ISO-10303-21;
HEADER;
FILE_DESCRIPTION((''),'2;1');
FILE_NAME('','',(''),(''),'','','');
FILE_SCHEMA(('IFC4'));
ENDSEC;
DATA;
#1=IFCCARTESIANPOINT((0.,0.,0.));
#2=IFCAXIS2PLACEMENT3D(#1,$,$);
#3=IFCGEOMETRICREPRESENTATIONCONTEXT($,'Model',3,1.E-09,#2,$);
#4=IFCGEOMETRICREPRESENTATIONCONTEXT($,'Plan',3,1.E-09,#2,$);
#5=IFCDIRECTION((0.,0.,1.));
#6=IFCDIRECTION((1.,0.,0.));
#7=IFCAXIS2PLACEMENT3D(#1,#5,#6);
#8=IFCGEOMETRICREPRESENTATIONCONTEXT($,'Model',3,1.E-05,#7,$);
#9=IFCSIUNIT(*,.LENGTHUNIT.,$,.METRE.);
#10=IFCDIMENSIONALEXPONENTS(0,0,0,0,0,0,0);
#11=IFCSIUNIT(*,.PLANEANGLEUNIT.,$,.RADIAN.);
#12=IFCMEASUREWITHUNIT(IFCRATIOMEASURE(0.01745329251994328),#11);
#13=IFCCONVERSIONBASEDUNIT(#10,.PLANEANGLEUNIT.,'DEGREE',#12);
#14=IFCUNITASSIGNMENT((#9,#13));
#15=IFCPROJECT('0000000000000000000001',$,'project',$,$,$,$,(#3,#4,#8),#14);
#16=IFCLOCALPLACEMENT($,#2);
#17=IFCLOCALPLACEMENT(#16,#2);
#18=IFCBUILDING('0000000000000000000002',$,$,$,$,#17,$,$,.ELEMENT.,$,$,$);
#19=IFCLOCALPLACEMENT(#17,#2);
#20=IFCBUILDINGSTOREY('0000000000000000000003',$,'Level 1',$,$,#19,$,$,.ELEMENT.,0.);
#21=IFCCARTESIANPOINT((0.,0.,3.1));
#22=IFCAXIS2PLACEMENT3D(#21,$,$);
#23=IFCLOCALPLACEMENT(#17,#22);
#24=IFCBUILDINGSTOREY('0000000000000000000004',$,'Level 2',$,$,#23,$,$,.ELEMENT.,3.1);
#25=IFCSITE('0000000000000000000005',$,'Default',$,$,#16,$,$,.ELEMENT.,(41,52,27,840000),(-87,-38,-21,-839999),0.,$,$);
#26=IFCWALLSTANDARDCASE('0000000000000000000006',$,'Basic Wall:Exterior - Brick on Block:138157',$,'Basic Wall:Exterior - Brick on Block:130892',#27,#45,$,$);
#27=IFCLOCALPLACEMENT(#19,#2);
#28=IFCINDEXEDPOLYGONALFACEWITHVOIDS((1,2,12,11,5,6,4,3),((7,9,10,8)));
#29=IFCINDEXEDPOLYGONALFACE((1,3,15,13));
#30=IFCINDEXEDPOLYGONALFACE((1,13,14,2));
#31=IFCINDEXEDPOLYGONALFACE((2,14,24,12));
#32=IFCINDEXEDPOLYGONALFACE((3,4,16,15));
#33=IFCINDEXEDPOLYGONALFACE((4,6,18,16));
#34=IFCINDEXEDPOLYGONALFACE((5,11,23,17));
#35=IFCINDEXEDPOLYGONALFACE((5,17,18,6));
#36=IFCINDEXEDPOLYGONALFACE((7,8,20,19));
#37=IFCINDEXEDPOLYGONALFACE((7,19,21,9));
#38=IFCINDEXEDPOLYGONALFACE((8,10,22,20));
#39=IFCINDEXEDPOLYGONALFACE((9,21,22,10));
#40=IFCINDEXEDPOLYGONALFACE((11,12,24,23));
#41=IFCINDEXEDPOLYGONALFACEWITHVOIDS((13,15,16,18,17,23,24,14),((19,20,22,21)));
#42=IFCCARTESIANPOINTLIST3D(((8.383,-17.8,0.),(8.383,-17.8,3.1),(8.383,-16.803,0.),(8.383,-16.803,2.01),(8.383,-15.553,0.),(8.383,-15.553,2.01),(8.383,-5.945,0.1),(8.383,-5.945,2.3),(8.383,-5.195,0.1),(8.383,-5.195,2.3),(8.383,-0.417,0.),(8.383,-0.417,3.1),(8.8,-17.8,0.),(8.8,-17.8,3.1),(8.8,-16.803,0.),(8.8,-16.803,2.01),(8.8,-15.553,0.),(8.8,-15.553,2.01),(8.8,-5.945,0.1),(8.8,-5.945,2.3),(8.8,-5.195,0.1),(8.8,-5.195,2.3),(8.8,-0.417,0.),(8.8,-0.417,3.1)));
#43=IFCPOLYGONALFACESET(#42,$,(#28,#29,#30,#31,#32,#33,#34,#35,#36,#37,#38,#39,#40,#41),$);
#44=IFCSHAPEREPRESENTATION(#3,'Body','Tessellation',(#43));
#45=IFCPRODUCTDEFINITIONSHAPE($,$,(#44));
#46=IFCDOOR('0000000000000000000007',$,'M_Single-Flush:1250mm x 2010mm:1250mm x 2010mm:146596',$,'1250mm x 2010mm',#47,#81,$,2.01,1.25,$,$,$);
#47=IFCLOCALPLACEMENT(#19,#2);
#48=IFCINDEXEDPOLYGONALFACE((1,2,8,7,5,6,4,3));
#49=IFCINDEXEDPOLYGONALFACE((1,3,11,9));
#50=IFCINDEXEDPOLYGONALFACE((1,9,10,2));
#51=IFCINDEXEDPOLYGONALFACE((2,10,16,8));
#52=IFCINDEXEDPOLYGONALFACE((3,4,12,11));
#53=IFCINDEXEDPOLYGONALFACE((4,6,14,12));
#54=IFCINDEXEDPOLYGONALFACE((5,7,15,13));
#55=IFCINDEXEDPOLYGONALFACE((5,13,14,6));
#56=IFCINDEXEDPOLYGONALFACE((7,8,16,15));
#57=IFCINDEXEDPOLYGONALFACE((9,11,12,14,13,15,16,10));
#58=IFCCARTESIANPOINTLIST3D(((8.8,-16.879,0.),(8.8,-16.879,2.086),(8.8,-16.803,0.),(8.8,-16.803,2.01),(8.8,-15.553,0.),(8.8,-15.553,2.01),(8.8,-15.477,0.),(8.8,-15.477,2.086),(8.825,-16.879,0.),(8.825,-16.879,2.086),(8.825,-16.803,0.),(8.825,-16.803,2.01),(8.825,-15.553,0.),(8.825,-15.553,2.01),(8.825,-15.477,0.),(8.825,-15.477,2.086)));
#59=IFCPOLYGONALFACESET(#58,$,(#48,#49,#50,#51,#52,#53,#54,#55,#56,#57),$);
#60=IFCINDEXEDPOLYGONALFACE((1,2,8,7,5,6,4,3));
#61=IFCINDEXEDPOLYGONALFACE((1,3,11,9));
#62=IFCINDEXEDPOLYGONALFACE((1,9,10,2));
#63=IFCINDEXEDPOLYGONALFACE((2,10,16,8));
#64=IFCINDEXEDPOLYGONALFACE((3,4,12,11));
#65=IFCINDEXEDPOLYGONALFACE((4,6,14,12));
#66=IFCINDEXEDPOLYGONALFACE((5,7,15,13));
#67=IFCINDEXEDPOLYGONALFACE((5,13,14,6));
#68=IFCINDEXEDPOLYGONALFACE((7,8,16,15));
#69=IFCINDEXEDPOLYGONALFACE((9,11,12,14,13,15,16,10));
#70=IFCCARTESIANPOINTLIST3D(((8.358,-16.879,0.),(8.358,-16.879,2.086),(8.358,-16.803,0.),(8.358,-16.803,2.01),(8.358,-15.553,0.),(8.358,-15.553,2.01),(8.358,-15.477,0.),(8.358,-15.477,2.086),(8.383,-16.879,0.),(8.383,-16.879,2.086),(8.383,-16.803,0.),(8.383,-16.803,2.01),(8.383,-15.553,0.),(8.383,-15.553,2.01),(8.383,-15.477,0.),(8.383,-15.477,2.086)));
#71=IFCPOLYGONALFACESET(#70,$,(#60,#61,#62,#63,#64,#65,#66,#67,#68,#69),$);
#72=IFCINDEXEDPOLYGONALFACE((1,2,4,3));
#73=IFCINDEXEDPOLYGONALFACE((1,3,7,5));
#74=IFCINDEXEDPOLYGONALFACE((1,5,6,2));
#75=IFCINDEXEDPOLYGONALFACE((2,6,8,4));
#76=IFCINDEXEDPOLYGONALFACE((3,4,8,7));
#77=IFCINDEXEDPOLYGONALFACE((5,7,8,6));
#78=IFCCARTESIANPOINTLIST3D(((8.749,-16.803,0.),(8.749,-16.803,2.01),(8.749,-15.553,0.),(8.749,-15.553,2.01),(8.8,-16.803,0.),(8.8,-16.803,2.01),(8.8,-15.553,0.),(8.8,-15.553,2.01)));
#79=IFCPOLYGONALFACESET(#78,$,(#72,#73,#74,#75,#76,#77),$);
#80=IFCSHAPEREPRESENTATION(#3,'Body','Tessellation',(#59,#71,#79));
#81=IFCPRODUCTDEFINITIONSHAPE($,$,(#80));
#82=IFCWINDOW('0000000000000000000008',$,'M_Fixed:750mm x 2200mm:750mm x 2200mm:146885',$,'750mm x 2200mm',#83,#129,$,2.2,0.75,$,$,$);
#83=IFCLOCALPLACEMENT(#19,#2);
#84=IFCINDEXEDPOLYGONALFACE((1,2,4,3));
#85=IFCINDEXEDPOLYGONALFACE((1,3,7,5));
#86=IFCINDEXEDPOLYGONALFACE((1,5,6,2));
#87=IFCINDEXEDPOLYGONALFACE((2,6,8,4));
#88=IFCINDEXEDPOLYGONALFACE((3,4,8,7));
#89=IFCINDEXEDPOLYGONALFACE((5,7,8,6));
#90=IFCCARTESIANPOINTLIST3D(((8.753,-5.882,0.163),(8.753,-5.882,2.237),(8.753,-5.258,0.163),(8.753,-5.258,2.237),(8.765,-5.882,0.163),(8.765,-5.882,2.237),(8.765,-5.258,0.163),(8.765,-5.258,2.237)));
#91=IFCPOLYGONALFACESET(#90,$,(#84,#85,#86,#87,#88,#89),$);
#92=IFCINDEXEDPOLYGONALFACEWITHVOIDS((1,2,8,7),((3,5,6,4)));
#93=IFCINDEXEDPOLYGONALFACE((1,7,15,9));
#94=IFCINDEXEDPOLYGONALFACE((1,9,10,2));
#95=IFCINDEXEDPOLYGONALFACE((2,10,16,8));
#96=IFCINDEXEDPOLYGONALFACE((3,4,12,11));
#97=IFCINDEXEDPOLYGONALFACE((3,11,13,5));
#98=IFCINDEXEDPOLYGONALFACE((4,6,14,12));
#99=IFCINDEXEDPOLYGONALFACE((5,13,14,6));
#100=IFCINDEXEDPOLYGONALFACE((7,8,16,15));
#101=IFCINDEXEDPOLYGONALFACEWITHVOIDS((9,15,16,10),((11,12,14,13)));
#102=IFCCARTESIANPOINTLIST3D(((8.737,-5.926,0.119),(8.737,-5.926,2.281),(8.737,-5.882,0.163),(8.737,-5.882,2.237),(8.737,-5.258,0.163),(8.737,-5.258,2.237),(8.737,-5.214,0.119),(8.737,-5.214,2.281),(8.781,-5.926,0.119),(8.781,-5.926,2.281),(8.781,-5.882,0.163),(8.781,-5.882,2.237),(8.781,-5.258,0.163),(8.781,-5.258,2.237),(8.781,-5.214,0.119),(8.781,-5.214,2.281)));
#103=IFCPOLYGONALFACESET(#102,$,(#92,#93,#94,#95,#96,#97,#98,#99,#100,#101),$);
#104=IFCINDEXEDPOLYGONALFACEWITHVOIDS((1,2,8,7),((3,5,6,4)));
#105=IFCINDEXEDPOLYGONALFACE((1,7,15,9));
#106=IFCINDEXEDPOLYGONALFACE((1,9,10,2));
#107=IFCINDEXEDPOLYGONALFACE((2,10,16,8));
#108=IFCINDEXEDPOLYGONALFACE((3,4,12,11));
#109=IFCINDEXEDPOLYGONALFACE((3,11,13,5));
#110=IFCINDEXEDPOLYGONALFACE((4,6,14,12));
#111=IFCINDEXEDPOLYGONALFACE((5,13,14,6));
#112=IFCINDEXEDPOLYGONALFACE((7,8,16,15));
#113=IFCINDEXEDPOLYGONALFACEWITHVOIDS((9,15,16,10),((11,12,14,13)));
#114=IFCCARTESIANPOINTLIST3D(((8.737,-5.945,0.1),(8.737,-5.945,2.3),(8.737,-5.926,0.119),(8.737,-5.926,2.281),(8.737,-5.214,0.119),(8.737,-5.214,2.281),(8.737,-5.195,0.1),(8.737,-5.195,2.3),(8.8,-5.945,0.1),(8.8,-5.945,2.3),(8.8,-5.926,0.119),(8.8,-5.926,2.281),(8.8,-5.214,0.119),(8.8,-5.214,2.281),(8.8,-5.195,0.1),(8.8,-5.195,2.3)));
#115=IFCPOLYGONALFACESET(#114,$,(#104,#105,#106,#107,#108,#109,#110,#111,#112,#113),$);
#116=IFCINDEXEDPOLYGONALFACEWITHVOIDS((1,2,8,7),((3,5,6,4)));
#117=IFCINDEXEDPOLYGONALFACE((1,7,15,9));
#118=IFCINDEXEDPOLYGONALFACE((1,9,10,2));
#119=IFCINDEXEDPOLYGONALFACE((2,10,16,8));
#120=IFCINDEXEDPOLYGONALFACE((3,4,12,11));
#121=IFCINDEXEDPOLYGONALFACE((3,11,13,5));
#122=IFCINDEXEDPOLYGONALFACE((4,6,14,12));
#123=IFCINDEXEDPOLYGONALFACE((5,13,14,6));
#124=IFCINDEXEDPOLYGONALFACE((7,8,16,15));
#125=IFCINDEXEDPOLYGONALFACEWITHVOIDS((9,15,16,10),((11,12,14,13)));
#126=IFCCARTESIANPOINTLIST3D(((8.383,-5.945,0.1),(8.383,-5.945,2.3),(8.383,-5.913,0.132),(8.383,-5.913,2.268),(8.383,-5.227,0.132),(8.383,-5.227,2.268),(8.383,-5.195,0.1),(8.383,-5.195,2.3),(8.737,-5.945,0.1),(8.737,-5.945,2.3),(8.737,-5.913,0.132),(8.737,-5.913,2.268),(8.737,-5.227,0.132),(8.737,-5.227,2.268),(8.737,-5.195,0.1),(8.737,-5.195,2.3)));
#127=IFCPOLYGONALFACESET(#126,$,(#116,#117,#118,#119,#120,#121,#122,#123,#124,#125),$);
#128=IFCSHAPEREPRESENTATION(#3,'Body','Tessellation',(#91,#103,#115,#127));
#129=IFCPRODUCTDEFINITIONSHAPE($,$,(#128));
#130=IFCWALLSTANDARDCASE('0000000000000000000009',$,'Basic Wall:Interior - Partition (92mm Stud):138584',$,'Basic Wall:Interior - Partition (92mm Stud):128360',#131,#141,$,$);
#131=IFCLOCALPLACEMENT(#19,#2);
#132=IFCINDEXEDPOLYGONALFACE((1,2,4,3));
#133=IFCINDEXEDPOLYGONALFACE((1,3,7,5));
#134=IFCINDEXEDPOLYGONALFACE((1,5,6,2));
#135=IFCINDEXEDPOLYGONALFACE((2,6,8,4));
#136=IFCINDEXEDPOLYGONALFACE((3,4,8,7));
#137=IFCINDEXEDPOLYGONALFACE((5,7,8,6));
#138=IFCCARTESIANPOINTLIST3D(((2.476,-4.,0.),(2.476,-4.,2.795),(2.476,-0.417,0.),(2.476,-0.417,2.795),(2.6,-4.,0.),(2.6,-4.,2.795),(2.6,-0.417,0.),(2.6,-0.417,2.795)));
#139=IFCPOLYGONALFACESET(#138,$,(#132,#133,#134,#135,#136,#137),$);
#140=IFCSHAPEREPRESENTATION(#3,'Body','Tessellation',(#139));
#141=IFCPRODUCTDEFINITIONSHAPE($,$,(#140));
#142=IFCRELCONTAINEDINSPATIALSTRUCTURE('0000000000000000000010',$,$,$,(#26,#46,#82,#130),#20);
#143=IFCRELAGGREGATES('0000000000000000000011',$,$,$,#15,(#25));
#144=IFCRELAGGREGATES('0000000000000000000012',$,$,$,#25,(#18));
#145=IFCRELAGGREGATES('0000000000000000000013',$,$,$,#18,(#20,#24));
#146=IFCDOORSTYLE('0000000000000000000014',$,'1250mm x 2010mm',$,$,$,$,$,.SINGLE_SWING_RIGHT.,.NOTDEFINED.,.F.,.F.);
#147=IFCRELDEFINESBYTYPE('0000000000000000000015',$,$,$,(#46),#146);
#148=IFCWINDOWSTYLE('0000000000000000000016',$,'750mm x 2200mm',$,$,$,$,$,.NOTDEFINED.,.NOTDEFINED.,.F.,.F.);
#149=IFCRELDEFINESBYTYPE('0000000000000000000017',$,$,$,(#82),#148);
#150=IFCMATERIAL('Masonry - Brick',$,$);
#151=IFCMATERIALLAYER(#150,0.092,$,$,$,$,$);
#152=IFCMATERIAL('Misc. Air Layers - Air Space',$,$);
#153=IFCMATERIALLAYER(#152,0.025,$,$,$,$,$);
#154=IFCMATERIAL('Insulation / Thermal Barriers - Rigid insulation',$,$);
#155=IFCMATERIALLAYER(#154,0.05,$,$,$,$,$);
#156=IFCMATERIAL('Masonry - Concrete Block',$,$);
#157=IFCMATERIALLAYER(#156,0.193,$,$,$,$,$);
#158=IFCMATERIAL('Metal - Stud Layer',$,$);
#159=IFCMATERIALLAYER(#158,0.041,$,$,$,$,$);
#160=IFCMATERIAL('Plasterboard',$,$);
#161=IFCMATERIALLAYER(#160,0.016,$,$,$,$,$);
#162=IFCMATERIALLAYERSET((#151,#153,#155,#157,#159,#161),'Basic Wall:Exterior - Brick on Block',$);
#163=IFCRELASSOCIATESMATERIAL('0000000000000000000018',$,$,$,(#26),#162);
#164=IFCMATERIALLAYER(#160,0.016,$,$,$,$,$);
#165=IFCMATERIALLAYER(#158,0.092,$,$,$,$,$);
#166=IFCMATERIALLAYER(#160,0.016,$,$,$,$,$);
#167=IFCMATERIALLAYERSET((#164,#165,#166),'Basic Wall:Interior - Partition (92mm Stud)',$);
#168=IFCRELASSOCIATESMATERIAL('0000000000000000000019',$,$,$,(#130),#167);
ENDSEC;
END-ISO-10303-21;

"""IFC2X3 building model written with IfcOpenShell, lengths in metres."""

from ifc_helpers import new_model, entity, si_unit, converted_unit, frame, frame_2d, origin, origin_with_axes, origin_2d_with_axis, place, context, project, spatial, polyline, rectangle, outline, extrude, source, transform, mapped, material, layer, layer_set, layer_usage, type_object, type_shapes, element, fill, save


model = new_model("IFC2X3")

# Units and contexts
model_context_1 = context("Model", 3, precision=1e-09, world=origin())
plan_context = context("Plan", 3, precision=1e-09, world=origin())
model_context_2 = context("Model", 3, precision=1e-05, world=origin_with_axes())
ifc_project = project(units=[si_unit("LENGTHUNIT", "METRE"), converted_unit("PLANEANGLEUNIT", "DEGREE", entity("IfcRatioMeasure", 0.01745329251994328), si_unit("PLANEANGLEUNIT", "RADIAN"), dimensions=[0, 0, 0, 0, 0, 0, 0])], contexts=[model_context_1, plan_context, model_context_2])

# Site, building, storey
site_placement = place(None, origin())
site = spatial("IfcSite", under=ifc_project, at=site_placement, Name="Default", CompositionType="ELEMENT", RefLatitude=(41, 52, 27, 840000), RefLongitude=(-87, -38, -21, -839999), RefElevation=0.0)
building_placement = place(site_placement, origin())
building = spatial("IfcBuilding", under=site, at=building_placement, CompositionType="ELEMENT")
storey_1_placement = place(building_placement, origin())
storey_1 = spatial("IfcBuildingStorey", under=building, at=storey_1_placement, Name="Level 1", CompositionType="ELEMENT", Elevation=0.0)

# Shared definitions
ifc_material_1 = material(Name="Masonry - Brick")
ifc_layer_1 = layer(ifc_material_1, 0.092)
ifc_material_2 = material(Name="Misc. Air Layers - Air Space")
ifc_layer_2 = layer(ifc_material_2, 0.025)
ifc_material_3 = material(Name="Insulation / Thermal Barriers - Rigid insulation")
ifc_layer_3 = layer(ifc_material_3, 0.05)
ifc_material_4 = material(Name="Masonry - Concrete Block")
ifc_layer_4 = layer(ifc_material_4, 0.193)
ifc_material_5 = material(Name="Metal - Stud Layer")
ifc_layer_5 = layer(ifc_material_5, 0.041)
ifc_material_6 = material(Name="Plasterboard")
ifc_layer_6 = layer(ifc_material_6, 0.016)
ifc_layer_set_1 = layer_set([ifc_layer_1, ifc_layer_2, ifc_layer_3, ifc_layer_4, ifc_layer_5, ifc_layer_6], Name="Basic Wall:Exterior - Brick on Block")

# Wall, openings, door, window
ifc_layer_usage_1 = layer_usage(ifc_layer_set_1, "AXIS2", "NEGATIVE", 0.2085)
wall_1_placement = place(storey_1_placement, frame((8.5915, -0.417, 0.0), z_axis=(0.0, 0.0, 1.0), x_axis=(0.0, -1.0, 0.0)))
wall_1 = element("IfcWallStandardCase", 1, at=wall_1_placement, inside=storey_1, material=ifc_layer_usage_1, Name="Basic Wall:Exterior - Brick on Block:138157", ObjectType="Basic Wall:Exterior - Brick on Block:130892", context=model_context_1, shape_type="SweptSolid", body=[
    extrude(rectangle(XDim=17.383, YDim=0.417, at=frame_2d((8.6915, 0.0), x_axis=(-1.0, 0.0))), origin(), (0.0, 0.0, 1.0), 3.1),
])
opening_1_placement = place(wall_1_placement, frame((15.136, -0.2085, 0.0)))
opening_1 = element("IfcOpeningElement", 2, at=opening_1_placement, cuts=wall_1, ObjectType="Opening", context=model_context_1, shape_type="SweptSolid", body=[
    extrude(rectangle(XDim=1.25, YDim=2.01, at=frame_2d((1.005, 0.625), x_axis=(0.0, 1.0))), frame((0.0, 0.0, 0.0), z_axis=(0.0, 1.0, 0.0), x_axis=(0.0, 0.0, 1.0)), (0.0, 0.0, 1.0), 0.417),
])
opening_2_placement = place(wall_1_placement, frame((4.778, -0.2085, 0.1)))
opening_2 = element("IfcOpeningElement", 3, at=opening_2_placement, cuts=wall_1, ObjectType="Opening", context=model_context_1, shape_type="SweptSolid", body=[
    extrude(rectangle(XDim=2.2, YDim=0.75, at=frame_2d((1.1, 0.375), x_axis=(1.0, 0.0))), frame((0.0, 0.0, 0.0), z_axis=(0.0, 1.0, 0.0), x_axis=(0.0, 0.0, 1.0)), (0.0, 0.0, 1.0), 0.417),
])
door_style_1 = type_object("IfcDoorStyle", Name="1250mm x 2010mm", ConstructionType="NOTDEFINED", OperationType="SINGLE_SWING_RIGHT", ParameterTakesPrecedence=False, Sizeable=False)
shared_shape_1 = source(origin(), model_context_1, "Body", "SweptSolid", [
    extrude(outline(polyline([(-0.701, -1.062), (0.701, -1.062), (0.701, 1.024), (0.625, 1.024), (0.625, -0.986), (-0.625, -0.986), (-0.625, 1.024), (-0.701, 1.024), (-0.701, -1.062)])), frame((0.625, 0.417, 1.024), z_axis=(0.0, 1.0, 0.0), x_axis=(1.0, 0.0, 0.0)), (0.0, 0.0, 1.0), 0.025),
    extrude(outline(polyline([(-1.062, -0.701), (1.024, -0.701), (1.024, -0.625), (-0.986, -0.625), (-0.986, 0.625), (1.024, 0.625), (1.024, 0.701), (-1.062, 0.701), (-1.062, -0.701)])), frame((0.625, -0.025, 1.024), z_axis=(0.0, 1.0, 0.0), x_axis=(0.0, 0.0, -1.0)), (0.0, 0.0, 1.0), 0.025),
    extrude(rectangle(XDim=0.051, YDim=1.25, at=origin_2d_with_axis()), frame((0.625, 0.3915, 0.0), z_axis=(0.0, 0.0, 1.0), x_axis=(0.0, 1.0, 0.0)), (0.0, 0.0, 1.0), 2.01),
])
type_shapes(door_style_1, [shared_shape_1])
door_1_placement = place(opening_1_placement, origin())
door_1 = element("IfcDoor", 4, at=door_1_placement, inside=storey_1, type_object=door_style_1, Name="M_Single-Flush:1250mm x 2010mm:1250mm x 2010mm:146596", ObjectType="1250mm x 2010mm", OverallHeight=2.01, OverallWidth=1.25, context=model_context_1, shape_type="MappedRepresentation", body=[
    mapped(shared_shape_1, transform((0.0, 0.0, 0.0), scale=1.0)),
])
fill(opening_1, door_1)
window_style_1 = type_object("IfcWindowStyle", Name="750mm x 2200mm", ConstructionType="NOTDEFINED", OperationType="NOTDEFINED", ParameterTakesPrecedence=False, Sizeable=False)
shared_shape_2 = source(origin(), model_context_1, "Body", "SweptSolid", [
    extrude(rectangle(XDim=0.012, YDim=0.624, at=origin_2d_with_axis()), frame((0.375, 0.376, 0.063), z_axis=(0.0, 0.0, 1.0), x_axis=(0.0, -1.0, 0.0)), (0.0, 0.0, 1.0), 2.074),
    extrude(outline(polyline([(-0.356, -1.081), (0.356, -1.081), (0.356, 1.081), (-0.356, 1.081), (-0.356, -1.081)]), holes=[polyline([(-0.312, -1.037), (-0.312, 1.037), (0.312, 1.037), (0.312, -1.037), (-0.312, -1.037)])]), frame((0.375, 0.354, 1.1), z_axis=(0.0, 1.0, 0.0), x_axis=(1.0, 0.0, 0.0)), (0.0, 0.0, 1.0), 0.044),
    extrude(outline(polyline([(-0.375, -1.1), (0.375, -1.1), (0.375, 1.1), (-0.375, 1.1), (-0.375, -1.1)]), holes=[polyline([(-0.356, -1.081), (-0.356, 1.081), (0.356, 1.081), (0.356, -1.081), (-0.356, -1.081)])]), frame((0.375, 0.354, 1.1), z_axis=(0.0, 1.0, 0.0), x_axis=(1.0, 0.0, 0.0)), (0.0, 0.0, 1.0), 0.063),
    extrude(outline(polyline([(-0.375, -1.1), (0.375, -1.1), (0.375, 1.1), (-0.375, 1.1), (-0.375, -1.1)]), holes=[polyline([(-0.343, -1.068), (-0.343, 1.068), (0.343, 1.068), (0.343, -1.068), (-0.343, -1.068)])]), frame((0.375, 0.0, 1.1), z_axis=(0.0, 1.0, 0.0), x_axis=(1.0, 0.0, 0.0)), (0.0, 0.0, 1.0), 0.354),
])
type_shapes(window_style_1, [shared_shape_2])
window_1_placement = place(opening_2_placement, origin())
window_1 = element("IfcWindow", 5, at=window_1_placement, inside=storey_1, type_object=window_style_1, Name="M_Fixed:750mm x 2200mm:750mm x 2200mm:146885", ObjectType="750mm x 2200mm", OverallHeight=2.2, OverallWidth=0.75, context=model_context_1, shape_type="MappedRepresentation", body=[
    mapped(shared_shape_2, transform((0.0, 0.0, 0.0), scale=1.0)),
])
fill(opening_2, window_1)

# Wall
ifc_layer_7 = layer(ifc_material_6, 0.016)
ifc_layer_8 = layer(ifc_material_5, 0.092)
ifc_layer_9 = layer(ifc_material_6, 0.016)
ifc_layer_set_2 = layer_set([ifc_layer_7, ifc_layer_8, ifc_layer_9], Name="Basic Wall:Interior - Partition (92mm Stud)")
ifc_layer_usage_2 = layer_usage(ifc_layer_set_2, "AXIS2", "NEGATIVE", 0.062)
wall_2_placement = place(storey_1_placement, frame((2.538, -0.417, 0.0), z_axis=(0.0, 0.0, 1.0), x_axis=(0.0, -1.0, 0.0)))
element("IfcWallStandardCase", 6, at=wall_2_placement, inside=storey_1, material=ifc_layer_usage_2, Name="Basic Wall:Interior - Partition (92mm Stud):138584", ObjectType="Basic Wall:Interior - Partition (92mm Stud):128360", context=model_context_1, shape_type="SweptSolid", body=[
    extrude(rectangle(XDim=3.583, YDim=0.124, at=frame_2d((1.7915, 0.0), x_axis=(-1.0, 0.0))), origin(), (0.0, 0.0, 1.0), 2.795),
])

# Shared definitions
storey_2_placement = place(building_placement, frame((0.0, 0.0, 3.1)))
storey_2 = spatial("IfcBuildingStorey", under=building, at=storey_2_placement, Name="Level 2", CompositionType="ELEMENT", Elevation=3.1)

save(model, "model.ifc")
